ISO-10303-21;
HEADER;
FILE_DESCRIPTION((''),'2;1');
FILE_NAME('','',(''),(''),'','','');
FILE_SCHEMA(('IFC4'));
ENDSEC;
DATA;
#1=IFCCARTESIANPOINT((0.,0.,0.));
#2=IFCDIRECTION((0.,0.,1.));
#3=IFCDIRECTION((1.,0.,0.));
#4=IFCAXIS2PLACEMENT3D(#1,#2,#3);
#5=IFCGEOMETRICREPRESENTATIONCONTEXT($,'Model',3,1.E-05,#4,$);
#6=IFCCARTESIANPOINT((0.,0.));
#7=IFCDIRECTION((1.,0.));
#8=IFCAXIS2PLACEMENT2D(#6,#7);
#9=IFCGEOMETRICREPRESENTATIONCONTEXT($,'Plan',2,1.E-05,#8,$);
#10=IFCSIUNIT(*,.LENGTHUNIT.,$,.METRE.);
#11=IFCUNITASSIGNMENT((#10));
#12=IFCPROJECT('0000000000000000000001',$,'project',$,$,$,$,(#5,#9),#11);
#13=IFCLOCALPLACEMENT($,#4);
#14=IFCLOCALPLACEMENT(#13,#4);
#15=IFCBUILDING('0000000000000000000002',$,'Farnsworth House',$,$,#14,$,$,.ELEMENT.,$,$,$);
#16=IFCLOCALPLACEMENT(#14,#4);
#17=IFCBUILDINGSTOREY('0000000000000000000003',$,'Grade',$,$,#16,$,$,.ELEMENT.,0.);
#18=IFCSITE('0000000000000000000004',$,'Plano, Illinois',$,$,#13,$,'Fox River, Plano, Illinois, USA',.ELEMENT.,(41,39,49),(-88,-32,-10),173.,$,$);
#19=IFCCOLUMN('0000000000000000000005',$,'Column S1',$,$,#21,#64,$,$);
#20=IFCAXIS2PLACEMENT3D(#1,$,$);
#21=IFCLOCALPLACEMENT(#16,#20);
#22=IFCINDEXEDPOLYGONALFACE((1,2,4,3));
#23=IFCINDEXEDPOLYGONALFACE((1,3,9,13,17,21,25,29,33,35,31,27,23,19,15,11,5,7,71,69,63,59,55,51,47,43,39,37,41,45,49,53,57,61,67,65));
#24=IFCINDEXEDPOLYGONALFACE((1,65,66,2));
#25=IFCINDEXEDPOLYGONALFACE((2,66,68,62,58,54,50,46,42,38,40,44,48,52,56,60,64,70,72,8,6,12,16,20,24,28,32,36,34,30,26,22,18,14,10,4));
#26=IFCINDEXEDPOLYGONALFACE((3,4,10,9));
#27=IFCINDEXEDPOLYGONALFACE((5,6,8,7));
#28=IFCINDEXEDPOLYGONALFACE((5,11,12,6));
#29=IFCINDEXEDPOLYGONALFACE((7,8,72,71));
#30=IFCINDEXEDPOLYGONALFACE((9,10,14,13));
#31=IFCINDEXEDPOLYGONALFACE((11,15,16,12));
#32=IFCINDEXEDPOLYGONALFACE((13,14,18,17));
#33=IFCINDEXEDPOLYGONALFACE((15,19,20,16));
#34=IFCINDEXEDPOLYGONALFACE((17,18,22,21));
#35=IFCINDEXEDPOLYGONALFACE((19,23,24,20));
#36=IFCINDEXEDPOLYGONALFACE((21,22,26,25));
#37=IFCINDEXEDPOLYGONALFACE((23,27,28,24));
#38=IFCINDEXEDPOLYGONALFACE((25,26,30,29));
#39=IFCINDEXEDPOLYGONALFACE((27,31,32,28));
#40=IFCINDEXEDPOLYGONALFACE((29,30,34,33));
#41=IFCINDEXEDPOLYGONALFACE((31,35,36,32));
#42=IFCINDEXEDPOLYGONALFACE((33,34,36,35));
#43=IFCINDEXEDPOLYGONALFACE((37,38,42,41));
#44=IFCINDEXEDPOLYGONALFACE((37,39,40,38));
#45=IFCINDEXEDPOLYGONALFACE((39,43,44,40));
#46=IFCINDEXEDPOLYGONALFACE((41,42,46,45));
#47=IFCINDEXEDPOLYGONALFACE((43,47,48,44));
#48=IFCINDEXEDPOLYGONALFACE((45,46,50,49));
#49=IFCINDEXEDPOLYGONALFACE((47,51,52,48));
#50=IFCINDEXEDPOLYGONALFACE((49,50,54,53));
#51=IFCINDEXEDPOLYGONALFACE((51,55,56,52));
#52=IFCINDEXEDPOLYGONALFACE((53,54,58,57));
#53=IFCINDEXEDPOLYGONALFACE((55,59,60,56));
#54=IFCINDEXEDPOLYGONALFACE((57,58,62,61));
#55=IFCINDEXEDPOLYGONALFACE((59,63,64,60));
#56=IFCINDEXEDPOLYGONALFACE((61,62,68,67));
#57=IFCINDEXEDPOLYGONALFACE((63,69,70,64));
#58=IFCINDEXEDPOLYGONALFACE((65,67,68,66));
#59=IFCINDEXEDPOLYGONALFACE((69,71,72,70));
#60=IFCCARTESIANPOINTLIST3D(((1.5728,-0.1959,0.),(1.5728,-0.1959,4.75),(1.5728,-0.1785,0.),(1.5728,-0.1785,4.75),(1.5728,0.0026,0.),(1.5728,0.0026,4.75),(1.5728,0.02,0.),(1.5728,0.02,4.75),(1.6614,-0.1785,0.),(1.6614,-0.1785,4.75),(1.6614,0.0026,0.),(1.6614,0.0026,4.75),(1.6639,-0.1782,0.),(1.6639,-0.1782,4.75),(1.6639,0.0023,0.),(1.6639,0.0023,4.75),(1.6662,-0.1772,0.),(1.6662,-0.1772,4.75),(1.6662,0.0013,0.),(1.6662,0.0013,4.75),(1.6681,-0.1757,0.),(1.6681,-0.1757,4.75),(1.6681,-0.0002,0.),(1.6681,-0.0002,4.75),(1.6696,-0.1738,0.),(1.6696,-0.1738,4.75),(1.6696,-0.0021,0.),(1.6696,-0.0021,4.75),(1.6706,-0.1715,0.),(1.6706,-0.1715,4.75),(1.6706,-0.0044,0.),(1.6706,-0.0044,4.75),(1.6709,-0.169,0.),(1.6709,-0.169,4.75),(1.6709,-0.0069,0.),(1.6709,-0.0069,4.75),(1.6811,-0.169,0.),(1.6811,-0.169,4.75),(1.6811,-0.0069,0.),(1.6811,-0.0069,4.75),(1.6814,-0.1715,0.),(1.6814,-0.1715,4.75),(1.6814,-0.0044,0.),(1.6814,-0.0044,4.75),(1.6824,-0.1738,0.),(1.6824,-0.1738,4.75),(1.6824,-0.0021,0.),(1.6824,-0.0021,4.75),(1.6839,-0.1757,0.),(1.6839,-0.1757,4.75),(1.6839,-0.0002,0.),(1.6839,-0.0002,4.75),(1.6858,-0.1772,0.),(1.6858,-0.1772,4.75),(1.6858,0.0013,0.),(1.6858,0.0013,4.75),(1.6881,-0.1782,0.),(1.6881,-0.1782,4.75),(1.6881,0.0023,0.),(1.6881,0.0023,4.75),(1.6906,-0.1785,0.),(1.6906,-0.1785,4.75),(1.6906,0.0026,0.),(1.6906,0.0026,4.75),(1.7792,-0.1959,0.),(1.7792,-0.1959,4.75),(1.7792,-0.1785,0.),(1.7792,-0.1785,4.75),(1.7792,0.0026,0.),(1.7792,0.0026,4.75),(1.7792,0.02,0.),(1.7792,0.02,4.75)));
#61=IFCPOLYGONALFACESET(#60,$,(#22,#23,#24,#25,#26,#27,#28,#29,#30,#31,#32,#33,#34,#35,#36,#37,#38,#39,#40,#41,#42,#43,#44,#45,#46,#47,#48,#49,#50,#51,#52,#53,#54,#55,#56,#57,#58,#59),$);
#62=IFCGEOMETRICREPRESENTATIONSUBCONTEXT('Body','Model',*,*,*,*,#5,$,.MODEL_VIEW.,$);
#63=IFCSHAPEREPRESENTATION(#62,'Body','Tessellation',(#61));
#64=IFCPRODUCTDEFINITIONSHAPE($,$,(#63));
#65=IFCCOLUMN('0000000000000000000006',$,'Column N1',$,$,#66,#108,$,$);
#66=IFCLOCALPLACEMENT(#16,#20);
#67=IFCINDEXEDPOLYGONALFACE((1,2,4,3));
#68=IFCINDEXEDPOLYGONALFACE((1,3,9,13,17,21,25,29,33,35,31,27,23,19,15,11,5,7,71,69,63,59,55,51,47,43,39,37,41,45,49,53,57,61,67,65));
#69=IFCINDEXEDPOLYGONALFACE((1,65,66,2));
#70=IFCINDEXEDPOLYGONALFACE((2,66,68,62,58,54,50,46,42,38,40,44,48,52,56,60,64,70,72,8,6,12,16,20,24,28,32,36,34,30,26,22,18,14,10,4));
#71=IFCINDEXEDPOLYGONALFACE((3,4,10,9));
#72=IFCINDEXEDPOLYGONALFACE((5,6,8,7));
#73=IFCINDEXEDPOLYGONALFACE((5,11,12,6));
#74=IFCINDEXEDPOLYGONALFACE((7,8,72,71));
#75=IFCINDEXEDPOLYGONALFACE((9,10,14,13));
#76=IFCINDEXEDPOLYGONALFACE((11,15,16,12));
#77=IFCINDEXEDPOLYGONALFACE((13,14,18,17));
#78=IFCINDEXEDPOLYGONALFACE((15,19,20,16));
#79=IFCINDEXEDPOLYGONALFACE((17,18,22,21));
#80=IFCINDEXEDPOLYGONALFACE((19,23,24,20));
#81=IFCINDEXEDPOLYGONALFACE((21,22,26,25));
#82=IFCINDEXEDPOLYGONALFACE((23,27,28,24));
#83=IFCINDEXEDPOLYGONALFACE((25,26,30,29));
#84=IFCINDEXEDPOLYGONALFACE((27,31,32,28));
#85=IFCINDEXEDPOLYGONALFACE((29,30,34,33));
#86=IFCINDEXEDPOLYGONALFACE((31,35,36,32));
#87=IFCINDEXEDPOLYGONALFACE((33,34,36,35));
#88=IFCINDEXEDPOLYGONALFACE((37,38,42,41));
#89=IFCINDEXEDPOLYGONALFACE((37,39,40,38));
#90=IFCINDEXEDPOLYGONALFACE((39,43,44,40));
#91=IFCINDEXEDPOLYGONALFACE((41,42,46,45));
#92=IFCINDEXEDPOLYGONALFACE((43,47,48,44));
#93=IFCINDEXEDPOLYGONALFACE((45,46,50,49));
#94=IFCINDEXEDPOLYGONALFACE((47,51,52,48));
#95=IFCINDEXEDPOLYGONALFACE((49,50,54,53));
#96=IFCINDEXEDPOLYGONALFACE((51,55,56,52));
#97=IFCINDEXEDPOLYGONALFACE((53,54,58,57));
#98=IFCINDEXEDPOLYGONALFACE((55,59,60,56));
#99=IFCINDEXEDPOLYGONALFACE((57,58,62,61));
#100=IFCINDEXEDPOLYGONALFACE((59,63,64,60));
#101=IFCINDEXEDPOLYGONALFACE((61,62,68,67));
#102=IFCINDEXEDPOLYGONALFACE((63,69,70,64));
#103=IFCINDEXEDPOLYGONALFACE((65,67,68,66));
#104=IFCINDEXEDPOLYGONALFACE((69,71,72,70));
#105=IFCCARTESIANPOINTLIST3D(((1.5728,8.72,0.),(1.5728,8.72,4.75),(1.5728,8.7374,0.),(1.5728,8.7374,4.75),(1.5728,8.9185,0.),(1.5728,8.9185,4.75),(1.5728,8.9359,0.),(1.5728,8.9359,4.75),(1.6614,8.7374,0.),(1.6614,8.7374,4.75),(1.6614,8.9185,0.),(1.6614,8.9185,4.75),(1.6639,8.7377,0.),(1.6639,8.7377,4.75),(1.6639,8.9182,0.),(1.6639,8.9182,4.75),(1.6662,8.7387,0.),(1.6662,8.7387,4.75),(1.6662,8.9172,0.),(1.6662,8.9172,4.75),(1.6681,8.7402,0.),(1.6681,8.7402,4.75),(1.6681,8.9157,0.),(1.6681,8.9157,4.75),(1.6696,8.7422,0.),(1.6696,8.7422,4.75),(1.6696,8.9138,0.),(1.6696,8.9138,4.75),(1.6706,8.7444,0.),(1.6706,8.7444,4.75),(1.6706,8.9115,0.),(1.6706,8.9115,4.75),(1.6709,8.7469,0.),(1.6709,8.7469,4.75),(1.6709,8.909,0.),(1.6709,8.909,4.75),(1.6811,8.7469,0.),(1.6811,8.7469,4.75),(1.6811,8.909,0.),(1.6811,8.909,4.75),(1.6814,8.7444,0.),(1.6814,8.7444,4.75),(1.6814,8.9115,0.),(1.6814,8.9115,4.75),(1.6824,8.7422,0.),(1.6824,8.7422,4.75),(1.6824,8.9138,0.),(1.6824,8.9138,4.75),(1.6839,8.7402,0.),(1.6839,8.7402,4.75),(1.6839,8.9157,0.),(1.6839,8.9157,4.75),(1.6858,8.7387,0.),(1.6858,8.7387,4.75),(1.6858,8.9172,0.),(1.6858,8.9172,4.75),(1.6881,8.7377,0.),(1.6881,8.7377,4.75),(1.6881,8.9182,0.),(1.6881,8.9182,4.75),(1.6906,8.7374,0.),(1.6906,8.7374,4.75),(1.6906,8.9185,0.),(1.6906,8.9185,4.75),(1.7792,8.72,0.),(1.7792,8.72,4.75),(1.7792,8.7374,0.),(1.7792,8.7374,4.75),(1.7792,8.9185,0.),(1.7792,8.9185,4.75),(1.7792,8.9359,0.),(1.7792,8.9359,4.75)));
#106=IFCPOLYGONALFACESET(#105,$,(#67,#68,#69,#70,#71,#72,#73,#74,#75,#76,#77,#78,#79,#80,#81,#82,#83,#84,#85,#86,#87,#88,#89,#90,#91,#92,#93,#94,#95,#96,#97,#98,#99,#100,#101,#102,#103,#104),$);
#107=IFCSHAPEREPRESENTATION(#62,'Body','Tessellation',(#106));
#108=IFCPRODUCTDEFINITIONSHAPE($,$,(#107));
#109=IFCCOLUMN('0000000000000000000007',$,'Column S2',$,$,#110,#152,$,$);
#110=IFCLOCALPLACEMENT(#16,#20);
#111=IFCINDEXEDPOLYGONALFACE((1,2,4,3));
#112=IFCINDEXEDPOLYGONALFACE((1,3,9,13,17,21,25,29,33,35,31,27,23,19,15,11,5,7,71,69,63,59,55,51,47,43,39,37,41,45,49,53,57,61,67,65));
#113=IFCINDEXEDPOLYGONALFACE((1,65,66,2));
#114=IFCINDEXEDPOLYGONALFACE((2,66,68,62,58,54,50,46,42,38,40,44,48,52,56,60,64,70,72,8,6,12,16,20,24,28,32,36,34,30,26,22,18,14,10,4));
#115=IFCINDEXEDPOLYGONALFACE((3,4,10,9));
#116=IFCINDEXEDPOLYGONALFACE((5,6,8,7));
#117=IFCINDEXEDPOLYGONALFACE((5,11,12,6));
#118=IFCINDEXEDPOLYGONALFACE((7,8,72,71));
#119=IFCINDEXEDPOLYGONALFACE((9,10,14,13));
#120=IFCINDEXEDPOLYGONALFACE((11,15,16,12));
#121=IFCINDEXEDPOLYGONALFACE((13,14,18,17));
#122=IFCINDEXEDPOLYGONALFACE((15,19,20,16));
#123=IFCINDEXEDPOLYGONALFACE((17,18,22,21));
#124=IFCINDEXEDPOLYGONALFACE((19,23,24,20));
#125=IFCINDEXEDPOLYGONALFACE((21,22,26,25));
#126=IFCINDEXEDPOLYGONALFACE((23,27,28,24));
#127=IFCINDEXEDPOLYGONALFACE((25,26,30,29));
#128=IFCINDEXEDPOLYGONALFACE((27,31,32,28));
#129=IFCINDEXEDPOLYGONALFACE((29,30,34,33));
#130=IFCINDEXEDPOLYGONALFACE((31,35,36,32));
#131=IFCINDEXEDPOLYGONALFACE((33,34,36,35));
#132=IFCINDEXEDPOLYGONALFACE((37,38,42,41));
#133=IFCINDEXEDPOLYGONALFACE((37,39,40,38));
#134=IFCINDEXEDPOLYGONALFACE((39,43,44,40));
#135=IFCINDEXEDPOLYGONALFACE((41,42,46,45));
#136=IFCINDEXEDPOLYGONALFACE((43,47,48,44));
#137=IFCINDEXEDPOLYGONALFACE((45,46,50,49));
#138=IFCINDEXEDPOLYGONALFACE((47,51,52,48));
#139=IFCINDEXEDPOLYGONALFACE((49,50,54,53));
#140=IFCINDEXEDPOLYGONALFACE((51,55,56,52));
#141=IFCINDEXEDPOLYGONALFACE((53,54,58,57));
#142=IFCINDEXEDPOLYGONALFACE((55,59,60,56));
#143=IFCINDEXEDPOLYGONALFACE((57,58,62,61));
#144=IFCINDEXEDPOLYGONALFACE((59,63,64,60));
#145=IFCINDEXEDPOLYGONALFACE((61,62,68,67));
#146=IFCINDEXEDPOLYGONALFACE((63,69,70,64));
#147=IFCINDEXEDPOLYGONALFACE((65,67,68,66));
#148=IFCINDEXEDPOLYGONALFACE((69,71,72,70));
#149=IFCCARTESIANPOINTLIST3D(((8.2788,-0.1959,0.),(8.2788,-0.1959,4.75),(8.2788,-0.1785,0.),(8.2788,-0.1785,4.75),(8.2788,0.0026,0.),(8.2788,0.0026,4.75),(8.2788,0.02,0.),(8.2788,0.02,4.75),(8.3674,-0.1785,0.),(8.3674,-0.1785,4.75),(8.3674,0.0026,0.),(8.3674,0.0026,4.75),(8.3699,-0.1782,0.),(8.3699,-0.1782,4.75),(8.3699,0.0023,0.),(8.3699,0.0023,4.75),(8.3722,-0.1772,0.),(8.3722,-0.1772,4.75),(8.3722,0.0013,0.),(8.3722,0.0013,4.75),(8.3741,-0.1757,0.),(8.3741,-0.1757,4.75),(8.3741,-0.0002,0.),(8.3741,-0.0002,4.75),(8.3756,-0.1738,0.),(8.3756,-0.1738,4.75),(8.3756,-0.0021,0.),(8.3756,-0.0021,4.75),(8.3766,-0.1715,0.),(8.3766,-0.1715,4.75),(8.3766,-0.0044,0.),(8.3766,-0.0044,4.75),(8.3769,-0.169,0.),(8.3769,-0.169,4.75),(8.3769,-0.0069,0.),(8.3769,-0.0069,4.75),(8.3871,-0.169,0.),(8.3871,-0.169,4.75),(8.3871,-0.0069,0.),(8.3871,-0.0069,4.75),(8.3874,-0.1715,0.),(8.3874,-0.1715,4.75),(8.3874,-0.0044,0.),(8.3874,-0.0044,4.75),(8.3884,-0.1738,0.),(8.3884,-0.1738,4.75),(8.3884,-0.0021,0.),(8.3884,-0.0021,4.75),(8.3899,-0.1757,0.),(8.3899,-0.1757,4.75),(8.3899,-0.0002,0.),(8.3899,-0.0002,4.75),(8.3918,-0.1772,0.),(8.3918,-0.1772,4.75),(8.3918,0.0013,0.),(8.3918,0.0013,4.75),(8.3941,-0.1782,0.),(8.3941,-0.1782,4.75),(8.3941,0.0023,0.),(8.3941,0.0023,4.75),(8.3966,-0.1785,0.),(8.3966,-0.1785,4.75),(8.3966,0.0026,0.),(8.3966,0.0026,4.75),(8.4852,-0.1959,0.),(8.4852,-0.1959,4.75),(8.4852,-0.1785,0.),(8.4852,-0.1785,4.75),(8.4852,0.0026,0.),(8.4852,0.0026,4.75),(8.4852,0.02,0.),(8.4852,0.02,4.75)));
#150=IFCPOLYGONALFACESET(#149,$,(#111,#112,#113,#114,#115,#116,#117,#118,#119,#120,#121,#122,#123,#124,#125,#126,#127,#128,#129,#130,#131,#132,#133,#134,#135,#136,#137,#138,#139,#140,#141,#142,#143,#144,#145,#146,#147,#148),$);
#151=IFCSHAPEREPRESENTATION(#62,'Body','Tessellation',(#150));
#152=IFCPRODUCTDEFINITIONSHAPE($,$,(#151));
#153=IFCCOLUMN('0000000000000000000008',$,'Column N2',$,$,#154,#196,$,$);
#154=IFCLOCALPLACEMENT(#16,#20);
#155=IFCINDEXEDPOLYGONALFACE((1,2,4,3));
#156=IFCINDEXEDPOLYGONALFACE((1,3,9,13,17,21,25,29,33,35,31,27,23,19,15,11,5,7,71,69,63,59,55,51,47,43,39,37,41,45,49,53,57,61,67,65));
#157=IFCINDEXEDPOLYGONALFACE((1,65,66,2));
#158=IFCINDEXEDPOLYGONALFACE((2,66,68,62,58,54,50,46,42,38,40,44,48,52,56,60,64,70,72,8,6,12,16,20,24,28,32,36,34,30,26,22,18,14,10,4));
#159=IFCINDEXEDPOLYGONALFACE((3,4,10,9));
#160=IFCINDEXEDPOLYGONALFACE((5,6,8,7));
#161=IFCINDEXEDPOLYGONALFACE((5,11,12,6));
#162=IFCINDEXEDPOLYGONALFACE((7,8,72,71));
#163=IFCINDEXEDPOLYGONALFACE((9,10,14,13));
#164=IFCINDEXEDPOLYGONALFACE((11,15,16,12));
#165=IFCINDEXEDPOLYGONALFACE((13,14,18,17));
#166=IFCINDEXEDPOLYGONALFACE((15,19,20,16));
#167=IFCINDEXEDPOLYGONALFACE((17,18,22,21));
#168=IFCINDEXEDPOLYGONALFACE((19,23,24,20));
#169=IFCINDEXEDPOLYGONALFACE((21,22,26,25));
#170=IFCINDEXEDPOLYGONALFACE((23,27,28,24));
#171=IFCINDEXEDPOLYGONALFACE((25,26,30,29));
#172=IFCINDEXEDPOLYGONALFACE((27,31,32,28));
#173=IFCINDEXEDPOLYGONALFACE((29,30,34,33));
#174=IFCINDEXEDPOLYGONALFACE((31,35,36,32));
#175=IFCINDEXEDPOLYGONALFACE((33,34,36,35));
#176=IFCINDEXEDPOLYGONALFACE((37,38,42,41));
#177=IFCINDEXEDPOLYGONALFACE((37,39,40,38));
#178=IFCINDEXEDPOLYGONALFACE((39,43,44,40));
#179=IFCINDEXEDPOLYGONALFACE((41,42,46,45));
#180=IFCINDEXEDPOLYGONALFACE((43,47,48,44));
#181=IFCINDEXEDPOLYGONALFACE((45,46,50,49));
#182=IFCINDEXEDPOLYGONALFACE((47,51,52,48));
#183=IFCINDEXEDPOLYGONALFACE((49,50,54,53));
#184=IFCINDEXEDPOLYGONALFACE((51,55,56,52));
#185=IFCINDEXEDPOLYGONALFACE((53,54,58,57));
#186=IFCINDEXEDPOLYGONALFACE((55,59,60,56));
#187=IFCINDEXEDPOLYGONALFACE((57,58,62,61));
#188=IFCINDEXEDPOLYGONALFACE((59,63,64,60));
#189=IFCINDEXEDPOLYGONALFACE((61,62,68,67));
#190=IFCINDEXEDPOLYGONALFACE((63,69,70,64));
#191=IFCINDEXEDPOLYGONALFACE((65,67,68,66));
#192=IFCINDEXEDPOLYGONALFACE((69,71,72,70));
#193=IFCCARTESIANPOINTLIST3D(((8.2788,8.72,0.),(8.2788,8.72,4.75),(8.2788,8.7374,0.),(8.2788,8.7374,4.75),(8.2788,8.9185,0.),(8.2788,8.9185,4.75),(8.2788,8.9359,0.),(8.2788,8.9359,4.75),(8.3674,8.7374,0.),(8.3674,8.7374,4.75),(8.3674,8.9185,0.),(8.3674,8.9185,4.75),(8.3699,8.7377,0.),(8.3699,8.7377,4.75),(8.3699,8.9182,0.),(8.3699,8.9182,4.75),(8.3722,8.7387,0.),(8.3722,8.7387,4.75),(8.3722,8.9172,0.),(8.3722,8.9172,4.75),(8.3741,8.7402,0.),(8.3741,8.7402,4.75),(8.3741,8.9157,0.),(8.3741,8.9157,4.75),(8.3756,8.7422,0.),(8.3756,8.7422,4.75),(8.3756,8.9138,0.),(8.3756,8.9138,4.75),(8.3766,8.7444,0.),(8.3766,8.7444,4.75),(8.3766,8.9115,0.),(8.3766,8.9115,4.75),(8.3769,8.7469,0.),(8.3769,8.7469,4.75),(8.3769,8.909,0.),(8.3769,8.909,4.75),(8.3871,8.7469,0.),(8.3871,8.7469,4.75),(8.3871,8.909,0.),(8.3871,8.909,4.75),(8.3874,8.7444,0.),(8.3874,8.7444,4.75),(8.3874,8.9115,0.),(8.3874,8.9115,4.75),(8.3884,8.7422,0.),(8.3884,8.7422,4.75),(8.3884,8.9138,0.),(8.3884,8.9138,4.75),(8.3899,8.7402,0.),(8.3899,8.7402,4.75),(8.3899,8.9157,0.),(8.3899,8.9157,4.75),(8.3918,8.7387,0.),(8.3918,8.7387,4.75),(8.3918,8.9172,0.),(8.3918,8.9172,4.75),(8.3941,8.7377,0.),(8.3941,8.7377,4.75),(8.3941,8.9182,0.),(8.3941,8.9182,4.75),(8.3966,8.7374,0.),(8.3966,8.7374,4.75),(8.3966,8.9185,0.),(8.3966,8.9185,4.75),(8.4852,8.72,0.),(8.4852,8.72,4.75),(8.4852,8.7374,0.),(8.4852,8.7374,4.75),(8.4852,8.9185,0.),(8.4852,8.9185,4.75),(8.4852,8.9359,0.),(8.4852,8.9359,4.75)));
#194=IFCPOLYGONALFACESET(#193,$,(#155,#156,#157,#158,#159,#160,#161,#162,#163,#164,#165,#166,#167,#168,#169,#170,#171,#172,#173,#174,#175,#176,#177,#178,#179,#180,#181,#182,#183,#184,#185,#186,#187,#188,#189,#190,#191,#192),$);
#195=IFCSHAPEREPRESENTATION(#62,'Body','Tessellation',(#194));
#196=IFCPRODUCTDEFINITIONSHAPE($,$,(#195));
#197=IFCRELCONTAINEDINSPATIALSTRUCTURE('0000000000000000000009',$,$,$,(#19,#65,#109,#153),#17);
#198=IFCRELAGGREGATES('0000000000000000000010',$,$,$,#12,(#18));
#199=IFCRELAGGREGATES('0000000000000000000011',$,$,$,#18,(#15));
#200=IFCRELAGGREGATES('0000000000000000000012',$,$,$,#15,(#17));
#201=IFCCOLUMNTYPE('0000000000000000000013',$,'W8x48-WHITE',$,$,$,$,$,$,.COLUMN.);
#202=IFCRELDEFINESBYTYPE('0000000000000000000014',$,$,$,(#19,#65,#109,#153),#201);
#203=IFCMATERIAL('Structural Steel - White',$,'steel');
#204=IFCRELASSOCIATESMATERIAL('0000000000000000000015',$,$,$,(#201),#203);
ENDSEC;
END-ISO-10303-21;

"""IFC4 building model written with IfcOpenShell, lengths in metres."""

from ifc_helpers import new_model, si_unit, frame, origin_with_axes, origin_2d_with_axis, place, context, subcontext, project, spatial, i_section, extrude, material, material_profile, profile_set, profile_usage, type_object, element, save


model = new_model("IFC4")

# Units and contexts
model_context = context("Model", 3, precision=1e-05, world=origin_with_axes())
plan_context = context("Plan", 2, precision=1e-05, world=origin_2d_with_axis())
body_context = subcontext(model_context, "Body", "Model", "MODEL_VIEW")
ifc_project = project(units=[si_unit("LENGTHUNIT", "METRE")], contexts=[model_context, plan_context])

# Site, building, storey
site_placement = place(None, origin_with_axes())
site = spatial("IfcSite", under=ifc_project, at=site_placement, Name="Plano, Illinois", LongName="Fox River, Plano, Illinois, USA", CompositionType="ELEMENT", RefLatitude=(41, 39, 49), RefLongitude=(-88, -32, -10), RefElevation=173.0)
building_placement = place(site_placement, origin_with_axes())
building = spatial("IfcBuilding", under=site, at=building_placement, Name="Farnsworth House", CompositionType="ELEMENT")
storey_placement = place(building_placement, origin_with_axes())
storey = spatial("IfcBuildingStorey", under=building, at=storey_placement, Name="Grade", CompositionType="ELEMENT", Elevation=0.0)

# Columns
ifc_material_1 = material(Name="Structural Steel - White", Category="steel")
ifc_material_profile = material_profile(ifc_material_1, i_section(OverallWidth=0.2064, OverallDepth=0.2159, WebThickness=0.0102, FlangeThickness=0.0174, FilletRadius=0.0095, at=origin_2d_with_axis()), Name="W8x48-STEEL", Category="STRUCTURAL", Priority=0)
ifc_profile_set = profile_set([ifc_material_profile], Name="W8x48-STEEL")
ifc_profile_usage = profile_usage(ifc_profile_set)
column_type = type_object("IfcColumnType", Name="W8x48-WHITE", PredefinedType="COLUMN", material=ifc_profile_usage)
for number, where, z_axis, x_axis, name in (
    (1, (1.676, -0.088, 0.0), (0.0, 0.0, 1.0), (1.0, 0.0, 0.0), "Column S1"),
    (2, (1.676, 8.828, 0.0), (0.0, 0.0, 1.0), (1.0, 0.0, 0.0), "Column N1"),
    (3, (8.382, -0.088, 0.0), (0.0, 0.0, 1.0), (1.0, 0.0, 0.0), "Column S2"),
    (4, (8.382, 8.828, 0.0), (0.0, 0.0, 1.0), (1.0, 0.0, 0.0), "Column N2"),
):
    element("IfcColumn", number, at=place(storey_placement, frame(where, z_axis=z_axis, x_axis=x_axis)), inside=storey, type_object=column_type, Name=name, context=body_context, shape_type="SweptSolid", body=[
        extrude(i_section(OverallWidth=0.2064, OverallDepth=0.2159, WebThickness=0.0102, FlangeThickness=0.0174, FilletRadius=0.0095, at=origin_2d_with_axis()), origin_with_axes(), (0.0, 0.0, 1.0), 4.75),
    ])

save(model, "model.ifc")
